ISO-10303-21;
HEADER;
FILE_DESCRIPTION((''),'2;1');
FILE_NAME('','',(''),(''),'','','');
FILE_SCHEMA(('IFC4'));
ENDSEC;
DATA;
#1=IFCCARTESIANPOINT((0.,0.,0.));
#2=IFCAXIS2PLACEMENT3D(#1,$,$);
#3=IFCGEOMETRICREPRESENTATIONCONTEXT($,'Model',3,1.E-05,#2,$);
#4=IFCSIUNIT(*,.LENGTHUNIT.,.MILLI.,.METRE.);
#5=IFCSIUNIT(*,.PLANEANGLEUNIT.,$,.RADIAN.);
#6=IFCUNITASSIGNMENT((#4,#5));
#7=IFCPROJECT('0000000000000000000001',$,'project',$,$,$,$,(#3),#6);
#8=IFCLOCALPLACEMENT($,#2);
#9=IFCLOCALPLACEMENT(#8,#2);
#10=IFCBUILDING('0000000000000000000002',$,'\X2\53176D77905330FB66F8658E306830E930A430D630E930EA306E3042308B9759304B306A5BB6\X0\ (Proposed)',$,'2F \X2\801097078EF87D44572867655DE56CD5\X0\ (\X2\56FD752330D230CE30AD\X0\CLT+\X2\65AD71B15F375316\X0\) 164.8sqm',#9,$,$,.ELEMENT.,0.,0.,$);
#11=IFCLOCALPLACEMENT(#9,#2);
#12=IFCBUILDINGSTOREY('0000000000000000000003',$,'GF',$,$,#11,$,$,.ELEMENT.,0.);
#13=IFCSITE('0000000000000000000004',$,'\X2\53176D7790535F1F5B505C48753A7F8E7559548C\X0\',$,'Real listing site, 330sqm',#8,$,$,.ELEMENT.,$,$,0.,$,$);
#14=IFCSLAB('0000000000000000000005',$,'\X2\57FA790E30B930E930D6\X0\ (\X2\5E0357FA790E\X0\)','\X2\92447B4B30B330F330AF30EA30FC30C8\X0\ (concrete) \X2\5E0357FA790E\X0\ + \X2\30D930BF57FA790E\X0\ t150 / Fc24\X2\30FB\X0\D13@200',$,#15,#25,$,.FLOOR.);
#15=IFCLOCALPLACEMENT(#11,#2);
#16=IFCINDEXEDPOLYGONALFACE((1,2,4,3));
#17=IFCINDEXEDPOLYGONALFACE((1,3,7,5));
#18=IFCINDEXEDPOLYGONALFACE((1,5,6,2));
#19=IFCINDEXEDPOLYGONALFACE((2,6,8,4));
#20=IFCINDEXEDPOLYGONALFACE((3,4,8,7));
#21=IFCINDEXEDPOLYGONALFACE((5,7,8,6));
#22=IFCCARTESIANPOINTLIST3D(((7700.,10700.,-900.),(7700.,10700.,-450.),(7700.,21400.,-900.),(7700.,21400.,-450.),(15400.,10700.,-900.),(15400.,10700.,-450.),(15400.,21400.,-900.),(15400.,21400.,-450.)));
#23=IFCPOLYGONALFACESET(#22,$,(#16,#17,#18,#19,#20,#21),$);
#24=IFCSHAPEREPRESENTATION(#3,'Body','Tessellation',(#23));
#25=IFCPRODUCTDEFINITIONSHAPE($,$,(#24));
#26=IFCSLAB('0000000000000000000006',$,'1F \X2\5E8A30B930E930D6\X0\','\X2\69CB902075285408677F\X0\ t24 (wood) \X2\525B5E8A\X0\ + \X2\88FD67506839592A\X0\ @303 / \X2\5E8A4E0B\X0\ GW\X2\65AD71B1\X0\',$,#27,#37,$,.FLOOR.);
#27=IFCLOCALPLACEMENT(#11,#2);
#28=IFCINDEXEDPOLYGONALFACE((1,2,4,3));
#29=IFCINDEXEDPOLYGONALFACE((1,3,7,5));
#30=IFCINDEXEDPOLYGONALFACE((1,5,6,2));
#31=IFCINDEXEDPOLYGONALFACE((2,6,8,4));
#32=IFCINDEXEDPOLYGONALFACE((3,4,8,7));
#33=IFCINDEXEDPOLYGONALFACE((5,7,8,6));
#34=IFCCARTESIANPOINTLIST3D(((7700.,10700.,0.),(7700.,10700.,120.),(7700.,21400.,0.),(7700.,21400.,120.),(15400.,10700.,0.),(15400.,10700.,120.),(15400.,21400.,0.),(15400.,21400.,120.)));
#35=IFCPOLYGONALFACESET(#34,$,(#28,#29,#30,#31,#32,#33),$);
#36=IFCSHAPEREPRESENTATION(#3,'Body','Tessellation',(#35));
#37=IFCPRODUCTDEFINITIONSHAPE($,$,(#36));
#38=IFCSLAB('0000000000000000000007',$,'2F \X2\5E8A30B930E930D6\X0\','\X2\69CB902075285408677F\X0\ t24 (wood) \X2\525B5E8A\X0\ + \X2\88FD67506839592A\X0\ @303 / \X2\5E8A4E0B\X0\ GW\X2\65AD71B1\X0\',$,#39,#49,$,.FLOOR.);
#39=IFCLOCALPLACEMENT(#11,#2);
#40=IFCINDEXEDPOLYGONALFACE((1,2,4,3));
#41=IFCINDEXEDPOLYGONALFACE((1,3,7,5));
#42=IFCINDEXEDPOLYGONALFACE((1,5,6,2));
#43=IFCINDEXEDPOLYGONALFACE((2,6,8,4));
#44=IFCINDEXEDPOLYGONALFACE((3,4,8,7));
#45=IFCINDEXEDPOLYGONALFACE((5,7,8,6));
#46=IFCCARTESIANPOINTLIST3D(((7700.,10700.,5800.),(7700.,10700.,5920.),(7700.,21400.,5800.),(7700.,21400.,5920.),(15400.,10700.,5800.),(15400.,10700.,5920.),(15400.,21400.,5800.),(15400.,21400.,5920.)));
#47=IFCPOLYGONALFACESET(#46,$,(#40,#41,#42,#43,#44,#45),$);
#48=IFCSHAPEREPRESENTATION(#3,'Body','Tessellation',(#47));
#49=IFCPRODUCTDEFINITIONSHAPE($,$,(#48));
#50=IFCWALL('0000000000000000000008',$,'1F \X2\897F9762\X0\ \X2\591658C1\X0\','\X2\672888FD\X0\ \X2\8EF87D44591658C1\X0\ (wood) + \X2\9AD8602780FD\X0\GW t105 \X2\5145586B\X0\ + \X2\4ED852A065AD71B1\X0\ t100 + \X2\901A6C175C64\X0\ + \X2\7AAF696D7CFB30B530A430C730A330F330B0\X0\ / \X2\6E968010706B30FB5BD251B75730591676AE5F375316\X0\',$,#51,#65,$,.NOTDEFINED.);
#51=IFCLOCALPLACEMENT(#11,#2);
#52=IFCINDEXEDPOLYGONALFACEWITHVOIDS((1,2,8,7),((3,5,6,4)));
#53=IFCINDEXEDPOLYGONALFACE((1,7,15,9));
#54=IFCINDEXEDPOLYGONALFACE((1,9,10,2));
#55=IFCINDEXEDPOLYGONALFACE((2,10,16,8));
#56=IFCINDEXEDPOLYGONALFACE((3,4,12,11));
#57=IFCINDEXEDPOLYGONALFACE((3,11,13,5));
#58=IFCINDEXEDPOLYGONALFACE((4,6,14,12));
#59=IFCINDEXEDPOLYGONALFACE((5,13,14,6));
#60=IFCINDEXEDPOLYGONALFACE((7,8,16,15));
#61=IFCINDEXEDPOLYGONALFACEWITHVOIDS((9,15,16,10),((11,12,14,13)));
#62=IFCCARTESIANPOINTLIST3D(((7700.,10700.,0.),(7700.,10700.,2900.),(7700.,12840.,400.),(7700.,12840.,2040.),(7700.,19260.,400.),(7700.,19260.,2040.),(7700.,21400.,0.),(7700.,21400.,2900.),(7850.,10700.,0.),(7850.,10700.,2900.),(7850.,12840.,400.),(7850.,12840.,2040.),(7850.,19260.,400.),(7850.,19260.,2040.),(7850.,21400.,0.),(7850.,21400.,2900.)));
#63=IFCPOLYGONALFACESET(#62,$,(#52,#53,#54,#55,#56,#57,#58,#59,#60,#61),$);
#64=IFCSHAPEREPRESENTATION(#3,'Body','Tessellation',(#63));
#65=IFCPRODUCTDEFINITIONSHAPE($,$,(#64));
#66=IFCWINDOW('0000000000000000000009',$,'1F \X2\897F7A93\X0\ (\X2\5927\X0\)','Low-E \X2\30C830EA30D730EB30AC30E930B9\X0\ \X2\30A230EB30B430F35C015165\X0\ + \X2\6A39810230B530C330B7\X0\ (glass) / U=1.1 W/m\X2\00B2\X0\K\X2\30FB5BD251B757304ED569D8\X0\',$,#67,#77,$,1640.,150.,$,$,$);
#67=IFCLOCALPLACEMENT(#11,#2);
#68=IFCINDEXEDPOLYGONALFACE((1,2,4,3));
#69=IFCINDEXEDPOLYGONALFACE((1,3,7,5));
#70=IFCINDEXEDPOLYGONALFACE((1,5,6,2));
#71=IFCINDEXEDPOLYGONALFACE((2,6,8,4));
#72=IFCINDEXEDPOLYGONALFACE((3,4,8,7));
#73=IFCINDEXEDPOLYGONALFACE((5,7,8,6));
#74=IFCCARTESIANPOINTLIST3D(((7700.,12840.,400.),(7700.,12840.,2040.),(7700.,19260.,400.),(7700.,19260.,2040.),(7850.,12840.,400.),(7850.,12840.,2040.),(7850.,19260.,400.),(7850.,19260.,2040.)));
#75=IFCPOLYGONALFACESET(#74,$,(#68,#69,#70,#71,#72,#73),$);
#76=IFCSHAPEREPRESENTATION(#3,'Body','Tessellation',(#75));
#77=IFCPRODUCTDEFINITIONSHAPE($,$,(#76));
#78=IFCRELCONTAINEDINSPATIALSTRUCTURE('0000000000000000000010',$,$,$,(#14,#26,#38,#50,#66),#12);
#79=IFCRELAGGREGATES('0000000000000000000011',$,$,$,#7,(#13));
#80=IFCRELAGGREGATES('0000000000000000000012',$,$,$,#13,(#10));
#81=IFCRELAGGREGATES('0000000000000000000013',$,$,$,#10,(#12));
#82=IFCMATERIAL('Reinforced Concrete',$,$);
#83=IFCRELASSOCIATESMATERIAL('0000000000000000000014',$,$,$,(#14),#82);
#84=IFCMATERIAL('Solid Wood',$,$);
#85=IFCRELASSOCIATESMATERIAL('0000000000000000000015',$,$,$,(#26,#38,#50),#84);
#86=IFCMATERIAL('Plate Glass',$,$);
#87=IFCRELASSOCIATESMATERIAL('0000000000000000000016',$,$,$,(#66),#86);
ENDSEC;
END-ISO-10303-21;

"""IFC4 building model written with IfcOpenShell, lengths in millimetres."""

from ifc_helpers import new_model, si_unit, frame, frame_2d, origin, place, context, project, spatial, rectangle, extrude, material, element, fill, save


model = new_model("IFC4")

# Units and contexts
model_context = context("Model", 3, precision=1e-05, world=origin())
ifc_project = project(units=[si_unit("LENGTHUNIT", "METRE", prefix="MILLI"), si_unit("PLANEANGLEUNIT", "RADIAN")], contexts=[model_context])

# Site, building, storey
site_placement = place(None, origin())
site = spatial("IfcSite", under=ifc_project, at=site_placement, Name="北海道弟子屈町美留和", ObjectType="Real listing site, 330sqm", CompositionType="ELEMENT", RefElevation=0.0)
building_placement = place(site_placement, origin())
building = spatial("IfcBuilding", under=site, at=building_placement, Name="北海道・書斎とライブラリのある静かな家 (Proposed)", ObjectType="2F 耐震軸組在来工法 (国産ヒノキCLT+断熱強化) 164.8sqm", CompositionType="ELEMENT", ElevationOfRefHeight=0.0, ElevationOfTerrain=0.0)
storey_placement = place(building_placement, origin())
storey = spatial("IfcBuildingStorey", under=building, at=storey_placement, Name="GF", CompositionType="ELEMENT", Elevation=0.0)

# Shared definitions
ifc_material_1 = material(Name="Solid Wood")

# Slabs
ifc_material_2 = material(Name="Reinforced Concrete")
slab_1_placement = place(storey_placement, frame((3850.0, 5350.0, -450.0)))
element("IfcSlab", 1, at=slab_1_placement, inside=storey, material=ifc_material_2, Name="基礎スラブ (布基礎)", Description="鉄筋コンクリート (concrete) 布基礎 + ベタ基礎 t150 / Fc24・D13@200", PredefinedType="FLOOR", context=model_context, shape_type="SweptSolid", body=[
    extrude(rectangle(XDim=7700.0, YDim=10700.0, at=frame_2d((3850.0, 5350.0))), frame((3850.0, 5350.0, -450.0)), (0.0, 0.0, 1.0), 450.0),
])
slab_2_placement = place(storey_placement, frame((3850.0, 5350.0, 0.0)))
element("IfcSlab", 2, at=slab_2_placement, inside=storey, material=ifc_material_1, Name="1F 床スラブ", Description="構造用合板 t24 (wood) 剛床 + 製材根太 @303 / 床下 GW断熱", PredefinedType="FLOOR", context=model_context, shape_type="SweptSolid", body=[
    extrude(rectangle(XDim=7700.0, YDim=10700.0, at=frame_2d((3850.0, 5350.0))), frame((3850.0, 5350.0, 0.0)), (0.0, 0.0, 1.0), 120.0),
])
slab_3_placement = place(storey_placement, frame((3850.0, 5350.0, 2900.0)))
element("IfcSlab", 3, at=slab_3_placement, inside=storey, material=ifc_material_1, Name="2F 床スラブ", Description="構造用合板 t24 (wood) 剛床 + 製材根太 @303 / 床下 GW断熱", PredefinedType="FLOOR", context=model_context, shape_type="SweptSolid", body=[
    extrude(rectangle(XDim=7700.0, YDim=10700.0, at=frame_2d((3850.0, 5350.0))), frame((3850.0, 5350.0, 2900.0)), (0.0, 0.0, 1.0), 120.0),
])

# Shared definitions
ifc_material_3 = material(Name="Plate Glass")

# Wall, opening, window
wall_1_placement = place(storey_placement, frame((3850.0, 5350.0, 0.0)))
wall_1 = element("IfcWall", 4, at=wall_1_placement, inside=storey, material=ifc_material_1, Name="1F 西面 外壁", Description="木製 軸組外壁 (wood) + 高性能GW t105 充填 + 付加断熱 t100 + 通気層 + 窯業系サイディング / 準耐火・寒冷地外皮強化", PredefinedType="NOTDEFINED", context=model_context, shape_type="SweptSolid", body=[
    extrude(rectangle(XDim=150.0, YDim=10700.0, at=frame_2d((75.0, 5350.0))), frame((3850.0, 5350.0, 0.0)), (0.0, 0.0, 1.0), 2900.0),
])
opening_1_placement = place(storey_placement, frame((3850.0, 6420.0, 200.0)))
opening_1 = element("IfcOpeningElement", 5, at=opening_1_placement, cuts=wall_1, PredefinedType="NOTDEFINED", context=model_context, shape_type="SweptSolid", body=[
    extrude(rectangle(XDim=150.0, YDim=6420.0, at=frame_2d((75.0, 3210.0))), frame((3850.0, 6420.0, 200.0)), (0.0, 0.0, 1.0), 1640.0),
])
window_1_placement = place(storey_placement, frame((3850.0, 6420.0, 200.0)))
window_1 = element("IfcWindow", 6, at=window_1_placement, inside=storey, material=ifc_material_3, Name="1F 西窓 (大)", Description="Low-E トリプルガラス アルゴン封入 + 樹脂サッシ (glass) / U=1.1 W/m²K・寒冷地仕様", OverallHeight=1640.0, OverallWidth=150.0, context=model_context, shape_type="SweptSolid", body=[
    extrude(rectangle(XDim=150.0, YDim=6420.0, at=frame_2d((75.0, 3210.0))), frame((3850.0, 6420.0, 200.0)), (0.0, 0.0, 1.0), 1640.0),
])
fill(opening_1, window_1)

save(model, "model.ifc")
